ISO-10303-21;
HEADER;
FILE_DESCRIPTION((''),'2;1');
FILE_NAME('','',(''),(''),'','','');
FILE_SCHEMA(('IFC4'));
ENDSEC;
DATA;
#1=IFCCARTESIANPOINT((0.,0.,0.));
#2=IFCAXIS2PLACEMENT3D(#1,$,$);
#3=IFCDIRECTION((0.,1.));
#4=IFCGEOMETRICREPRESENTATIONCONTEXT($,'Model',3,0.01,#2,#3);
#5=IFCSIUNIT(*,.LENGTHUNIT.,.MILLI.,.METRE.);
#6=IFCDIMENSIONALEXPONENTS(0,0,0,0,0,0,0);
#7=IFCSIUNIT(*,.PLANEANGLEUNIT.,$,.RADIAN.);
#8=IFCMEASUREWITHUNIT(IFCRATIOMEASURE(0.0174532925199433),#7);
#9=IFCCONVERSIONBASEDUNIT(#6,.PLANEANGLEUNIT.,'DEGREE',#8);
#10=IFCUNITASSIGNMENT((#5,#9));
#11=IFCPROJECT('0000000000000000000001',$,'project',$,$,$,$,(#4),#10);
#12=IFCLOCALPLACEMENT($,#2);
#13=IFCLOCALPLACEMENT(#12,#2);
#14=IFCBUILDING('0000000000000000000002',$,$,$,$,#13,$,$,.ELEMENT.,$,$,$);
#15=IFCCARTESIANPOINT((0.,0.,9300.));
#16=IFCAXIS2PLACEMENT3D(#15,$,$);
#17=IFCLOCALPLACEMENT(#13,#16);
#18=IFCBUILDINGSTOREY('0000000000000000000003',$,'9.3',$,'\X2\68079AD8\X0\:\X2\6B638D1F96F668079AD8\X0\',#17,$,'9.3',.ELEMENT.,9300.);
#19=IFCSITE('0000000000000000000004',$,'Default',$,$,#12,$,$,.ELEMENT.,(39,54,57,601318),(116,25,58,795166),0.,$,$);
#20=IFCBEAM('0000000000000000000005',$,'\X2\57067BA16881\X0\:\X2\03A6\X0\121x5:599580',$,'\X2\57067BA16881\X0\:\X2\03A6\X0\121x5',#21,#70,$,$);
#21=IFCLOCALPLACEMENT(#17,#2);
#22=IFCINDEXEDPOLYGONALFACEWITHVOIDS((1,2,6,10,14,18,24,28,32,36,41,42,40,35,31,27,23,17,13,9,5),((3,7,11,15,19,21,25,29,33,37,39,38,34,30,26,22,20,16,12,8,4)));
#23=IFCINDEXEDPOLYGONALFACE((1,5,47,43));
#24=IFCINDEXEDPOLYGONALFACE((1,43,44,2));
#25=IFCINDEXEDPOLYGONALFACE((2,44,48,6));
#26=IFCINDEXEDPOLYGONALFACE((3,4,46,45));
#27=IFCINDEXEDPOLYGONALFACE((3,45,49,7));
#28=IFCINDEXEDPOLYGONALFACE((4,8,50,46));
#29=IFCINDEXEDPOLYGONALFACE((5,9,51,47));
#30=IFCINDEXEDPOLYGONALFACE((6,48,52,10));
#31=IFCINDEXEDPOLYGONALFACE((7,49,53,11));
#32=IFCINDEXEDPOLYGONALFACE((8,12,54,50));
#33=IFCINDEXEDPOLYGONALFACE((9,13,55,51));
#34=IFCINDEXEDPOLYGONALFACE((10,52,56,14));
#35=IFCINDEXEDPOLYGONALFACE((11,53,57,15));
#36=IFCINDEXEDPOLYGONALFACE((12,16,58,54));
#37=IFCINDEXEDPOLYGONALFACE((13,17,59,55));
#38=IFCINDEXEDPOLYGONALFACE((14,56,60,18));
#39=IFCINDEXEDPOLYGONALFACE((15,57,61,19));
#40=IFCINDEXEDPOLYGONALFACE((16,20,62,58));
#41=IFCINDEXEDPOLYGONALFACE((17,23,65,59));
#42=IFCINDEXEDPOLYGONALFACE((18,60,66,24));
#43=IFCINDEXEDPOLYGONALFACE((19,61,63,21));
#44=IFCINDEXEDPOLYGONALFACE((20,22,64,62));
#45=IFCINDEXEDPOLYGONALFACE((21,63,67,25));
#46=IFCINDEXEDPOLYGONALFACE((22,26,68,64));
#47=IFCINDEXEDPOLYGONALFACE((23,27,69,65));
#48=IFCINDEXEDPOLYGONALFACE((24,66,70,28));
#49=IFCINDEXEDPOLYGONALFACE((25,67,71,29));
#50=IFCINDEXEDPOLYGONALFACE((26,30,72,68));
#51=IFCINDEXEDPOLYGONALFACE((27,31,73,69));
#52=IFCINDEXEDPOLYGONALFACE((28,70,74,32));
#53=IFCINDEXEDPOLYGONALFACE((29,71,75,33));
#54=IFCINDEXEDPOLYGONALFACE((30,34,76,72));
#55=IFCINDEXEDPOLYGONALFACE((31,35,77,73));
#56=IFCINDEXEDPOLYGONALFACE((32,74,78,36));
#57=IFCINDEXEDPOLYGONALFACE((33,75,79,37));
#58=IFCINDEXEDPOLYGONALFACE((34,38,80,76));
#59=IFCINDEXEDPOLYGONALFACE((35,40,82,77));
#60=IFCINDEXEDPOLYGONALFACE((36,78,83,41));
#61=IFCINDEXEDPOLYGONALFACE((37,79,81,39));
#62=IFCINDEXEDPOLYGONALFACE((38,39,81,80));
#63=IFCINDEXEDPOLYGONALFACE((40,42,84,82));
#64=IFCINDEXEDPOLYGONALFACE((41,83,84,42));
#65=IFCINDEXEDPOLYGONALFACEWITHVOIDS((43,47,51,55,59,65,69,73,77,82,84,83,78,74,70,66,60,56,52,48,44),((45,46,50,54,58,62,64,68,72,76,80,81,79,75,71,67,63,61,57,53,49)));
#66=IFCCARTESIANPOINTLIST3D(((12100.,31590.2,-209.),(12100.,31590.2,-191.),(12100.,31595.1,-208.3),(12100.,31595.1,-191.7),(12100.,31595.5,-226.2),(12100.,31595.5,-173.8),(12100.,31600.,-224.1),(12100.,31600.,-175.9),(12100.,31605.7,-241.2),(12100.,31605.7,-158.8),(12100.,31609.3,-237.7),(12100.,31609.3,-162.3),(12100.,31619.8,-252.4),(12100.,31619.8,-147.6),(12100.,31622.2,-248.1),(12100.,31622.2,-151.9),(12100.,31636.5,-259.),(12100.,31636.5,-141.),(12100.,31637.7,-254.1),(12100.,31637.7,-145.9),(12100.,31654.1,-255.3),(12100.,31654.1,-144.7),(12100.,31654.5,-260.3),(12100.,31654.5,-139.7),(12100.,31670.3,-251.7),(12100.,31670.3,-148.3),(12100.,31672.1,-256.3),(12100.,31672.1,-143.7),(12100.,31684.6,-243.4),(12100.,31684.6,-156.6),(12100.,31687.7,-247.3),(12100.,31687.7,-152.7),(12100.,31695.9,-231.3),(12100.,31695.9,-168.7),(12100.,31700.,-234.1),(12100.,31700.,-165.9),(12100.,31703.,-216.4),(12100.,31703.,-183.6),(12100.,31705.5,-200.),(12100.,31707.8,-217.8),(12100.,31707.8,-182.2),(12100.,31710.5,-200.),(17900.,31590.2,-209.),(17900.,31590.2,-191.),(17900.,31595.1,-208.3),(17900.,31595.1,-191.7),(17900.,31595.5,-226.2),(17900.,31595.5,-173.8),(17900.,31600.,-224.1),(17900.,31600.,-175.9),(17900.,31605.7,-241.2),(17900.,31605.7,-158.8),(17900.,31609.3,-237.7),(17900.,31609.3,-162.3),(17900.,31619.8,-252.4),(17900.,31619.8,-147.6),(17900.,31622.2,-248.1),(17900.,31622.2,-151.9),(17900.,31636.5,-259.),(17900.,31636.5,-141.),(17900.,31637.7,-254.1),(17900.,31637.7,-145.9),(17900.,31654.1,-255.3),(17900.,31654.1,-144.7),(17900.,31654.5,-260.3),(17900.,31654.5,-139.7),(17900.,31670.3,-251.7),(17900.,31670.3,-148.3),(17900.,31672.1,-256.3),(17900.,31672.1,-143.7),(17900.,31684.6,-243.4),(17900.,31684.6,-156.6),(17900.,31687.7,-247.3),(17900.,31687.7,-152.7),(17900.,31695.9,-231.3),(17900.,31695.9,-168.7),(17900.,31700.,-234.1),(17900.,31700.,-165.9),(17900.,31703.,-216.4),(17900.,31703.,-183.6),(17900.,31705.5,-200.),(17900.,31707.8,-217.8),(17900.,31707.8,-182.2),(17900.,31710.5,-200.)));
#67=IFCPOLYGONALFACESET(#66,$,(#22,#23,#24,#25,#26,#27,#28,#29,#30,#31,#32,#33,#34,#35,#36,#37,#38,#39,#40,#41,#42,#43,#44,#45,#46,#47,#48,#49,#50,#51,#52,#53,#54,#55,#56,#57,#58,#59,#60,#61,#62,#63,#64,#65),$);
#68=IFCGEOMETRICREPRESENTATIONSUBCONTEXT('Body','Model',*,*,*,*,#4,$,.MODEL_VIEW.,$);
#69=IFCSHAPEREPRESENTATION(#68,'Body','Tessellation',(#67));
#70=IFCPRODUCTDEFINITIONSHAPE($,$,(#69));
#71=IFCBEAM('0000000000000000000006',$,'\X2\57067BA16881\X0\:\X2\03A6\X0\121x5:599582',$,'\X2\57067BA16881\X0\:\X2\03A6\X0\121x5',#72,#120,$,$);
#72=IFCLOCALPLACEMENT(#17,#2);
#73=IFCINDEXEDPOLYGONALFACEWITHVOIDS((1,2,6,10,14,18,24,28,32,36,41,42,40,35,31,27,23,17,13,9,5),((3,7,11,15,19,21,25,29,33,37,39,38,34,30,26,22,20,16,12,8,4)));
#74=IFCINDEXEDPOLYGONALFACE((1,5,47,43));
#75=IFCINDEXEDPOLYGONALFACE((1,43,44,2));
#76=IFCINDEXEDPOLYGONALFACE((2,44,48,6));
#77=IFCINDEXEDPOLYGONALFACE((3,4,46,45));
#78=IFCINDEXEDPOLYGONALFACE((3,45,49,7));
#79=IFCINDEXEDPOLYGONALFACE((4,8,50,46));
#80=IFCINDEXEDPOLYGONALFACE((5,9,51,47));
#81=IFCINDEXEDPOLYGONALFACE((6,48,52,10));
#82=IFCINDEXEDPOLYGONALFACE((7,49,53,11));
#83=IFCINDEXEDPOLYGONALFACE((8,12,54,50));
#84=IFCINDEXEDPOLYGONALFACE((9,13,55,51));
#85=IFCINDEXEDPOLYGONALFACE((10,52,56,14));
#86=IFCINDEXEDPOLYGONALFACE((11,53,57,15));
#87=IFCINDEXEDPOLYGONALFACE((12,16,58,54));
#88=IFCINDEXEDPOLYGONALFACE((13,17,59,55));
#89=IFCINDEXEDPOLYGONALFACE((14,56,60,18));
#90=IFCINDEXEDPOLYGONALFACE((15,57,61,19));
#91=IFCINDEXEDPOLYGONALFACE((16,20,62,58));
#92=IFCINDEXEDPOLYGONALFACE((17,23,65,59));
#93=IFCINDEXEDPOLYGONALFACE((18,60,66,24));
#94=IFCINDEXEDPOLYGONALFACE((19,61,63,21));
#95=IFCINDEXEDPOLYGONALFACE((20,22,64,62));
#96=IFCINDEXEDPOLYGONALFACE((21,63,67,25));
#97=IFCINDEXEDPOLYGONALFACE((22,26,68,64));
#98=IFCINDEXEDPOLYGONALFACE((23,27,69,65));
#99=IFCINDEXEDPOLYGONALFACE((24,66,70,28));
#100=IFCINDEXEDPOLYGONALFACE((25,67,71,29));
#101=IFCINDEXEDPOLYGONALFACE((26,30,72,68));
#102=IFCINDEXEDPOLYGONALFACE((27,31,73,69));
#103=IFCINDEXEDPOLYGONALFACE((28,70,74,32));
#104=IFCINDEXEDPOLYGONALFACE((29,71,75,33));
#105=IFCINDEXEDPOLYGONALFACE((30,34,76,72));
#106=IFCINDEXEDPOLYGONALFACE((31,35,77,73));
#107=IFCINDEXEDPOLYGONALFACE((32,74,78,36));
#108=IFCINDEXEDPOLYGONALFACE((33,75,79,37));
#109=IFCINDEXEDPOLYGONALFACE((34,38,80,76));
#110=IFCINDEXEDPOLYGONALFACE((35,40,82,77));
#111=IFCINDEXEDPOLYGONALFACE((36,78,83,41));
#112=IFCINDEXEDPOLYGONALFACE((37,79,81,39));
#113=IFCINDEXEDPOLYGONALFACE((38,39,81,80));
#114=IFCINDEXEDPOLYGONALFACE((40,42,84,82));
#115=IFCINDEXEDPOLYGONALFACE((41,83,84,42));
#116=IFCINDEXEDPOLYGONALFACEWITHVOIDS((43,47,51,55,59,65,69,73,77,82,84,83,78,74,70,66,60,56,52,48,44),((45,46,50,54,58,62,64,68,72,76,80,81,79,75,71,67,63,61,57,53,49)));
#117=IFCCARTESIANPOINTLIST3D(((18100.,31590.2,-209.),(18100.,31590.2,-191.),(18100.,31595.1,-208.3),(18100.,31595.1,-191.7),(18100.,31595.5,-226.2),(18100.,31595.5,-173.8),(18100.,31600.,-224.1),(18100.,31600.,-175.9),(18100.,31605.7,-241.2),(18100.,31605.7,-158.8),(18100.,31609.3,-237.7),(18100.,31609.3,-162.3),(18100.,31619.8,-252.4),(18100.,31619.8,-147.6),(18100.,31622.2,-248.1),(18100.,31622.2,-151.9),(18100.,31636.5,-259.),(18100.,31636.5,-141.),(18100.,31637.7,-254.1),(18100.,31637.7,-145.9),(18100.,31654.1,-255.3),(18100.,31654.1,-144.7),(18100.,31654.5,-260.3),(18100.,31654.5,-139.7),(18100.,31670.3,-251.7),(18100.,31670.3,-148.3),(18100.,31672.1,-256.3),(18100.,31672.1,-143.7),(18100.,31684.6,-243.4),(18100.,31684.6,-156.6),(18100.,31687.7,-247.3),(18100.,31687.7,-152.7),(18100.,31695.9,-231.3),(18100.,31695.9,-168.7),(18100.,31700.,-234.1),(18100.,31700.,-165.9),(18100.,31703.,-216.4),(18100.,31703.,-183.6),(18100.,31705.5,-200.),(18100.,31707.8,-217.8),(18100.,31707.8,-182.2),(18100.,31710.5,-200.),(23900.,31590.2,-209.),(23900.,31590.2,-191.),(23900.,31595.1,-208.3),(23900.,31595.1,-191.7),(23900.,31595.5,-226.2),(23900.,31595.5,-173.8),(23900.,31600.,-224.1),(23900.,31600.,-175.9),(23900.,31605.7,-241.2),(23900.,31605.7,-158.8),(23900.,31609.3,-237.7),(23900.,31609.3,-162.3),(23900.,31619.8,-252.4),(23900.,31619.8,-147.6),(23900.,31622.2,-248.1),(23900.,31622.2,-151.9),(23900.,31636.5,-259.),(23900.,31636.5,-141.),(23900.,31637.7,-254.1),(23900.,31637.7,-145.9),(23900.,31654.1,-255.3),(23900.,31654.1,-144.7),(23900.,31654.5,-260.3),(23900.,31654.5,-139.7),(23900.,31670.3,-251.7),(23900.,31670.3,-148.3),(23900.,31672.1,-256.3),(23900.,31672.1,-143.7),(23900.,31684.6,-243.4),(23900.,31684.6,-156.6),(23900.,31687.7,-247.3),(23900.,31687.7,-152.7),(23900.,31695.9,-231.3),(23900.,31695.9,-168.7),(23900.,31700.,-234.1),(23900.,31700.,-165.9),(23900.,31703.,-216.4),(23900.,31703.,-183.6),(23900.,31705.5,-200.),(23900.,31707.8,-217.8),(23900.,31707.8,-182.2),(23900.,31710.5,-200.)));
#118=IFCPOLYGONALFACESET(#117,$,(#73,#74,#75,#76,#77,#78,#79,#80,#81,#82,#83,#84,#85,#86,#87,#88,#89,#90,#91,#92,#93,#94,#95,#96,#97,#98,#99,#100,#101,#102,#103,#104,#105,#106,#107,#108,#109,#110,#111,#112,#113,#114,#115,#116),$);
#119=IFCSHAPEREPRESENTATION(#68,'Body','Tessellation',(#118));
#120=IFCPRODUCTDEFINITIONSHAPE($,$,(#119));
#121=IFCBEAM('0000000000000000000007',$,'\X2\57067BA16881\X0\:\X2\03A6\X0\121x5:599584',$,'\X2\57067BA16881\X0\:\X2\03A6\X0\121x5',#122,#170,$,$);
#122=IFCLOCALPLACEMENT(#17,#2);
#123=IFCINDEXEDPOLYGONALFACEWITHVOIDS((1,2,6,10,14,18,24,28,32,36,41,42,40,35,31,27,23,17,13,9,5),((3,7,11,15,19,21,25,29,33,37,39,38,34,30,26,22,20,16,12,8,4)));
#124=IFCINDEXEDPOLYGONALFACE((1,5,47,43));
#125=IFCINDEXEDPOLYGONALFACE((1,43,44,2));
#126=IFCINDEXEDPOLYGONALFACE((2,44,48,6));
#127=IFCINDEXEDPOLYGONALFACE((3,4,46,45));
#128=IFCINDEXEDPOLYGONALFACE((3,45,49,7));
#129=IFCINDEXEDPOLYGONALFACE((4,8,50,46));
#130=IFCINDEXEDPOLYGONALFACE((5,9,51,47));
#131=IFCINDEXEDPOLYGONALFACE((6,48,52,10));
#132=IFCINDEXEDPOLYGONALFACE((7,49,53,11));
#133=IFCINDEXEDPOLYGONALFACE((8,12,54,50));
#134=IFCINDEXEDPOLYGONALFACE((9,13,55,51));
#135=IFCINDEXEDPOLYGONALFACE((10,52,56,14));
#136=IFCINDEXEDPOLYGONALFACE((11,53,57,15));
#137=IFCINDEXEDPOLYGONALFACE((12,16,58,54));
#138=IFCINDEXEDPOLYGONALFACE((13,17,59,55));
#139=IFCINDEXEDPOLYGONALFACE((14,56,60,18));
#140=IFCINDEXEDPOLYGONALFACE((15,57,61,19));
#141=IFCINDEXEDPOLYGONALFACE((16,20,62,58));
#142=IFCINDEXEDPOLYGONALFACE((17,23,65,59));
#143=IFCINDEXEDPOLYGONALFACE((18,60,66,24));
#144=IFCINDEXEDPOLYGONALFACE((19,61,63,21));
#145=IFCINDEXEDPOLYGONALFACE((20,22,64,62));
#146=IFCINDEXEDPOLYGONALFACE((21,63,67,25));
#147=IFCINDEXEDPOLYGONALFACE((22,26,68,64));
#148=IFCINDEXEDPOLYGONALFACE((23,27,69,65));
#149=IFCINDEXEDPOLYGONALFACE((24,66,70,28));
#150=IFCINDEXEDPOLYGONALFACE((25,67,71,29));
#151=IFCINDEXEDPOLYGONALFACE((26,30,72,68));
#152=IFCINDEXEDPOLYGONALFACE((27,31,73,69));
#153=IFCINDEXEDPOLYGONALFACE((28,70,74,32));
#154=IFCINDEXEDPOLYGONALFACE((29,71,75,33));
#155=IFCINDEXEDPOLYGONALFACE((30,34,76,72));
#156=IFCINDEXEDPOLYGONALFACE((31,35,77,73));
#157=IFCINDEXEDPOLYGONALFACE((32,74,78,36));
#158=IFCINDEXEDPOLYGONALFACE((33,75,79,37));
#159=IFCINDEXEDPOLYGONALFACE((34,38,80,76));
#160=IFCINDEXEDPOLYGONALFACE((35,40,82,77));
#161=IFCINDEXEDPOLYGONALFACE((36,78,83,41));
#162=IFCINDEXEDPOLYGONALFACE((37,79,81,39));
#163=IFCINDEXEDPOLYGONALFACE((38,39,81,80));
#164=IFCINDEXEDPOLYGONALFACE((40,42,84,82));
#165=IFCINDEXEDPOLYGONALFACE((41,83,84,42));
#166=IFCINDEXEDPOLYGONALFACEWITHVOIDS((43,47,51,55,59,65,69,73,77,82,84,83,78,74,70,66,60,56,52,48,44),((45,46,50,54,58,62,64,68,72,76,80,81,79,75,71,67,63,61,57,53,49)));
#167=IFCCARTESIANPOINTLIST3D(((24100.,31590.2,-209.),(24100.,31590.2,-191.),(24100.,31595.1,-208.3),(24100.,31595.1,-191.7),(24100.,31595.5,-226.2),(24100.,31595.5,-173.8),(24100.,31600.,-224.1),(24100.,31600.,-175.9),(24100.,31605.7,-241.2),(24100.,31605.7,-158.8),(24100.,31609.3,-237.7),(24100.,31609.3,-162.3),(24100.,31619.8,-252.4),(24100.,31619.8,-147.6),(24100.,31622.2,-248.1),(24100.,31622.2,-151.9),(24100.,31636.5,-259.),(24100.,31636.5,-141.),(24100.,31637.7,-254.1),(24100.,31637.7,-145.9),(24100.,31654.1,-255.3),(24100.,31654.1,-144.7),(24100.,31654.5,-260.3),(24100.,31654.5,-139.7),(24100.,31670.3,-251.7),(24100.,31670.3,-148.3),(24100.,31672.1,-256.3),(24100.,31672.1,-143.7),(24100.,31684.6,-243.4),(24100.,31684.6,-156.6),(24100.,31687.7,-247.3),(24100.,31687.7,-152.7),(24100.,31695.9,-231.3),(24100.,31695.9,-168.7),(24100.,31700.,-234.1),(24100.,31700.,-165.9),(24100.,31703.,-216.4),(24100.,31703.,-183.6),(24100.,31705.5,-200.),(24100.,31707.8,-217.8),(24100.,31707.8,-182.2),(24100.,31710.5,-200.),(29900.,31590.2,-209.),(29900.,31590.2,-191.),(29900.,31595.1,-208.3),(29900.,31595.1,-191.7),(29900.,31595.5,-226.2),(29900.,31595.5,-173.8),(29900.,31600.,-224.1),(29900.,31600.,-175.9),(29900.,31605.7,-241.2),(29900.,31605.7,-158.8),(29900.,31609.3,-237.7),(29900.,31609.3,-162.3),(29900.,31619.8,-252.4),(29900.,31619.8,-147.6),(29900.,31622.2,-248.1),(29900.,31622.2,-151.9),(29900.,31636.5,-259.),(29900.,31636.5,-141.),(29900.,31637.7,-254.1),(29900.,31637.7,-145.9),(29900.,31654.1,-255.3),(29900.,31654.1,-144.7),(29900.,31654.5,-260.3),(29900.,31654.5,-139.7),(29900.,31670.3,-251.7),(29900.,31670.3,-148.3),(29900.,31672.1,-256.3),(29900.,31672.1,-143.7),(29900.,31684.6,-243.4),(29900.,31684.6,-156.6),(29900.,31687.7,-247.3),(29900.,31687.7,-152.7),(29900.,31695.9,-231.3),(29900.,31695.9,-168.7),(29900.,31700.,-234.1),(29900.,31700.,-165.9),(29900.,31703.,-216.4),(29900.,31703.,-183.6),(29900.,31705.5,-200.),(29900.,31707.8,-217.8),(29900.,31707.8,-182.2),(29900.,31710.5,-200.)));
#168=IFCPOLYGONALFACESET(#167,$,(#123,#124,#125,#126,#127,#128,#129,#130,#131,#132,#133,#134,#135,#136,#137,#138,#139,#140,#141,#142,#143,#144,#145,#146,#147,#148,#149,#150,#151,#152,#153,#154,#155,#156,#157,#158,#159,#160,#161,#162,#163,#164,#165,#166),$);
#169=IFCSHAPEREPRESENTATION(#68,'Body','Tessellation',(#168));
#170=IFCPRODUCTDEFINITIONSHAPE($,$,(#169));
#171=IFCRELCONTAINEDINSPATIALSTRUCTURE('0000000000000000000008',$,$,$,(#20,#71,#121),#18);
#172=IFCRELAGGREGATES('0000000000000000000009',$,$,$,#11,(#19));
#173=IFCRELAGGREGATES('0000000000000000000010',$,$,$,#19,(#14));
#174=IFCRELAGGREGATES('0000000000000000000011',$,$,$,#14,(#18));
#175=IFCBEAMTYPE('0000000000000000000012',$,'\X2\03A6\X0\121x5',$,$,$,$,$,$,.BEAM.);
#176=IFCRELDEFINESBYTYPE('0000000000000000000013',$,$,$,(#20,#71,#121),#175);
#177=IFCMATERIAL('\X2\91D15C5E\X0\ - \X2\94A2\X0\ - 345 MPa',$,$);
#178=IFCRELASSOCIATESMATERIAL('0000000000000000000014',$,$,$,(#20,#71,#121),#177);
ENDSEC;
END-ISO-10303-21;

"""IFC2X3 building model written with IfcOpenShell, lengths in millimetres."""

from ifc_helpers import new_model, entity, si_unit, converted_unit, direction, frame, origin, origin_2d_with_axis, place, context, subcontext, project, spatial, hollow_circle, extrude, material, type_object, element, save


model = new_model("IFC2X3")

# Units and contexts
model_context = context("Model", 3, precision=0.01, world=origin(), true_north=direction((0.0, 1.0)))
body_context = subcontext(model_context, "Body", "Model", "MODEL_VIEW")
ifc_project = project(units=[si_unit("LENGTHUNIT", "METRE", prefix="MILLI"), converted_unit("PLANEANGLEUNIT", "DEGREE", entity("IfcRatioMeasure", 0.0174532925199433), si_unit("PLANEANGLEUNIT", "RADIAN"), dimensions=[0, 0, 0, 0, 0, 0, 0])], contexts=[model_context])

# Site, building, storey
site_placement = place(None, origin())
site = spatial("IfcSite", under=ifc_project, at=site_placement, Name="Default", CompositionType="ELEMENT", RefLatitude=(39, 54, 57, 601318), RefLongitude=(116, 25, 58, 795166), RefElevation=0.0)
building_placement = place(site_placement, origin())
building = spatial("IfcBuilding", under=site, at=building_placement, CompositionType="ELEMENT")
storey_placement = place(building_placement, frame((0.0, 0.0, 9300.0)))
storey = spatial("IfcBuildingStorey", under=building, at=storey_placement, Name="9.3", ObjectType="标高:正负零标高", LongName="9.3", CompositionType="ELEMENT", Elevation=9300.0)

# Beams
ifc_material = material(Name="金属 - 钢 - 345 MPa")
beam_type_1 = type_object("IfcBeamType", Name="Φ121x5", PredefinedType="BEAM")
for number, where, name in (
    (1, (12000.0, 31650.0, 0.0), "圆管梁:Φ121x5:599580"),
    (2, (18000.0, 31650.0, 0.0), "圆管梁:Φ121x5:599582"),
    (3, (24000.0, 31650.0, 0.0), "圆管梁:Φ121x5:599584"),
):
    element("IfcBeam", number, at=place(storey_placement, frame(where)), inside=storey, type_object=beam_type_1, material=ifc_material, Name=name, ObjectType="圆管梁:Φ121x5", context=body_context, shape_type="SweptSolid", body=[
        extrude(hollow_circle(Radius=60.5, WallThickness=5.0, at=origin_2d_with_axis()), frame((100.0, 0.0, -200.0), z_axis=(1.0, 0.0, 0.0), x_axis=(0.0, 1.0, 0.0)), (0.0, 0.0, 1.0), 5800.0),
    ])

save(model, "model.ifc")
